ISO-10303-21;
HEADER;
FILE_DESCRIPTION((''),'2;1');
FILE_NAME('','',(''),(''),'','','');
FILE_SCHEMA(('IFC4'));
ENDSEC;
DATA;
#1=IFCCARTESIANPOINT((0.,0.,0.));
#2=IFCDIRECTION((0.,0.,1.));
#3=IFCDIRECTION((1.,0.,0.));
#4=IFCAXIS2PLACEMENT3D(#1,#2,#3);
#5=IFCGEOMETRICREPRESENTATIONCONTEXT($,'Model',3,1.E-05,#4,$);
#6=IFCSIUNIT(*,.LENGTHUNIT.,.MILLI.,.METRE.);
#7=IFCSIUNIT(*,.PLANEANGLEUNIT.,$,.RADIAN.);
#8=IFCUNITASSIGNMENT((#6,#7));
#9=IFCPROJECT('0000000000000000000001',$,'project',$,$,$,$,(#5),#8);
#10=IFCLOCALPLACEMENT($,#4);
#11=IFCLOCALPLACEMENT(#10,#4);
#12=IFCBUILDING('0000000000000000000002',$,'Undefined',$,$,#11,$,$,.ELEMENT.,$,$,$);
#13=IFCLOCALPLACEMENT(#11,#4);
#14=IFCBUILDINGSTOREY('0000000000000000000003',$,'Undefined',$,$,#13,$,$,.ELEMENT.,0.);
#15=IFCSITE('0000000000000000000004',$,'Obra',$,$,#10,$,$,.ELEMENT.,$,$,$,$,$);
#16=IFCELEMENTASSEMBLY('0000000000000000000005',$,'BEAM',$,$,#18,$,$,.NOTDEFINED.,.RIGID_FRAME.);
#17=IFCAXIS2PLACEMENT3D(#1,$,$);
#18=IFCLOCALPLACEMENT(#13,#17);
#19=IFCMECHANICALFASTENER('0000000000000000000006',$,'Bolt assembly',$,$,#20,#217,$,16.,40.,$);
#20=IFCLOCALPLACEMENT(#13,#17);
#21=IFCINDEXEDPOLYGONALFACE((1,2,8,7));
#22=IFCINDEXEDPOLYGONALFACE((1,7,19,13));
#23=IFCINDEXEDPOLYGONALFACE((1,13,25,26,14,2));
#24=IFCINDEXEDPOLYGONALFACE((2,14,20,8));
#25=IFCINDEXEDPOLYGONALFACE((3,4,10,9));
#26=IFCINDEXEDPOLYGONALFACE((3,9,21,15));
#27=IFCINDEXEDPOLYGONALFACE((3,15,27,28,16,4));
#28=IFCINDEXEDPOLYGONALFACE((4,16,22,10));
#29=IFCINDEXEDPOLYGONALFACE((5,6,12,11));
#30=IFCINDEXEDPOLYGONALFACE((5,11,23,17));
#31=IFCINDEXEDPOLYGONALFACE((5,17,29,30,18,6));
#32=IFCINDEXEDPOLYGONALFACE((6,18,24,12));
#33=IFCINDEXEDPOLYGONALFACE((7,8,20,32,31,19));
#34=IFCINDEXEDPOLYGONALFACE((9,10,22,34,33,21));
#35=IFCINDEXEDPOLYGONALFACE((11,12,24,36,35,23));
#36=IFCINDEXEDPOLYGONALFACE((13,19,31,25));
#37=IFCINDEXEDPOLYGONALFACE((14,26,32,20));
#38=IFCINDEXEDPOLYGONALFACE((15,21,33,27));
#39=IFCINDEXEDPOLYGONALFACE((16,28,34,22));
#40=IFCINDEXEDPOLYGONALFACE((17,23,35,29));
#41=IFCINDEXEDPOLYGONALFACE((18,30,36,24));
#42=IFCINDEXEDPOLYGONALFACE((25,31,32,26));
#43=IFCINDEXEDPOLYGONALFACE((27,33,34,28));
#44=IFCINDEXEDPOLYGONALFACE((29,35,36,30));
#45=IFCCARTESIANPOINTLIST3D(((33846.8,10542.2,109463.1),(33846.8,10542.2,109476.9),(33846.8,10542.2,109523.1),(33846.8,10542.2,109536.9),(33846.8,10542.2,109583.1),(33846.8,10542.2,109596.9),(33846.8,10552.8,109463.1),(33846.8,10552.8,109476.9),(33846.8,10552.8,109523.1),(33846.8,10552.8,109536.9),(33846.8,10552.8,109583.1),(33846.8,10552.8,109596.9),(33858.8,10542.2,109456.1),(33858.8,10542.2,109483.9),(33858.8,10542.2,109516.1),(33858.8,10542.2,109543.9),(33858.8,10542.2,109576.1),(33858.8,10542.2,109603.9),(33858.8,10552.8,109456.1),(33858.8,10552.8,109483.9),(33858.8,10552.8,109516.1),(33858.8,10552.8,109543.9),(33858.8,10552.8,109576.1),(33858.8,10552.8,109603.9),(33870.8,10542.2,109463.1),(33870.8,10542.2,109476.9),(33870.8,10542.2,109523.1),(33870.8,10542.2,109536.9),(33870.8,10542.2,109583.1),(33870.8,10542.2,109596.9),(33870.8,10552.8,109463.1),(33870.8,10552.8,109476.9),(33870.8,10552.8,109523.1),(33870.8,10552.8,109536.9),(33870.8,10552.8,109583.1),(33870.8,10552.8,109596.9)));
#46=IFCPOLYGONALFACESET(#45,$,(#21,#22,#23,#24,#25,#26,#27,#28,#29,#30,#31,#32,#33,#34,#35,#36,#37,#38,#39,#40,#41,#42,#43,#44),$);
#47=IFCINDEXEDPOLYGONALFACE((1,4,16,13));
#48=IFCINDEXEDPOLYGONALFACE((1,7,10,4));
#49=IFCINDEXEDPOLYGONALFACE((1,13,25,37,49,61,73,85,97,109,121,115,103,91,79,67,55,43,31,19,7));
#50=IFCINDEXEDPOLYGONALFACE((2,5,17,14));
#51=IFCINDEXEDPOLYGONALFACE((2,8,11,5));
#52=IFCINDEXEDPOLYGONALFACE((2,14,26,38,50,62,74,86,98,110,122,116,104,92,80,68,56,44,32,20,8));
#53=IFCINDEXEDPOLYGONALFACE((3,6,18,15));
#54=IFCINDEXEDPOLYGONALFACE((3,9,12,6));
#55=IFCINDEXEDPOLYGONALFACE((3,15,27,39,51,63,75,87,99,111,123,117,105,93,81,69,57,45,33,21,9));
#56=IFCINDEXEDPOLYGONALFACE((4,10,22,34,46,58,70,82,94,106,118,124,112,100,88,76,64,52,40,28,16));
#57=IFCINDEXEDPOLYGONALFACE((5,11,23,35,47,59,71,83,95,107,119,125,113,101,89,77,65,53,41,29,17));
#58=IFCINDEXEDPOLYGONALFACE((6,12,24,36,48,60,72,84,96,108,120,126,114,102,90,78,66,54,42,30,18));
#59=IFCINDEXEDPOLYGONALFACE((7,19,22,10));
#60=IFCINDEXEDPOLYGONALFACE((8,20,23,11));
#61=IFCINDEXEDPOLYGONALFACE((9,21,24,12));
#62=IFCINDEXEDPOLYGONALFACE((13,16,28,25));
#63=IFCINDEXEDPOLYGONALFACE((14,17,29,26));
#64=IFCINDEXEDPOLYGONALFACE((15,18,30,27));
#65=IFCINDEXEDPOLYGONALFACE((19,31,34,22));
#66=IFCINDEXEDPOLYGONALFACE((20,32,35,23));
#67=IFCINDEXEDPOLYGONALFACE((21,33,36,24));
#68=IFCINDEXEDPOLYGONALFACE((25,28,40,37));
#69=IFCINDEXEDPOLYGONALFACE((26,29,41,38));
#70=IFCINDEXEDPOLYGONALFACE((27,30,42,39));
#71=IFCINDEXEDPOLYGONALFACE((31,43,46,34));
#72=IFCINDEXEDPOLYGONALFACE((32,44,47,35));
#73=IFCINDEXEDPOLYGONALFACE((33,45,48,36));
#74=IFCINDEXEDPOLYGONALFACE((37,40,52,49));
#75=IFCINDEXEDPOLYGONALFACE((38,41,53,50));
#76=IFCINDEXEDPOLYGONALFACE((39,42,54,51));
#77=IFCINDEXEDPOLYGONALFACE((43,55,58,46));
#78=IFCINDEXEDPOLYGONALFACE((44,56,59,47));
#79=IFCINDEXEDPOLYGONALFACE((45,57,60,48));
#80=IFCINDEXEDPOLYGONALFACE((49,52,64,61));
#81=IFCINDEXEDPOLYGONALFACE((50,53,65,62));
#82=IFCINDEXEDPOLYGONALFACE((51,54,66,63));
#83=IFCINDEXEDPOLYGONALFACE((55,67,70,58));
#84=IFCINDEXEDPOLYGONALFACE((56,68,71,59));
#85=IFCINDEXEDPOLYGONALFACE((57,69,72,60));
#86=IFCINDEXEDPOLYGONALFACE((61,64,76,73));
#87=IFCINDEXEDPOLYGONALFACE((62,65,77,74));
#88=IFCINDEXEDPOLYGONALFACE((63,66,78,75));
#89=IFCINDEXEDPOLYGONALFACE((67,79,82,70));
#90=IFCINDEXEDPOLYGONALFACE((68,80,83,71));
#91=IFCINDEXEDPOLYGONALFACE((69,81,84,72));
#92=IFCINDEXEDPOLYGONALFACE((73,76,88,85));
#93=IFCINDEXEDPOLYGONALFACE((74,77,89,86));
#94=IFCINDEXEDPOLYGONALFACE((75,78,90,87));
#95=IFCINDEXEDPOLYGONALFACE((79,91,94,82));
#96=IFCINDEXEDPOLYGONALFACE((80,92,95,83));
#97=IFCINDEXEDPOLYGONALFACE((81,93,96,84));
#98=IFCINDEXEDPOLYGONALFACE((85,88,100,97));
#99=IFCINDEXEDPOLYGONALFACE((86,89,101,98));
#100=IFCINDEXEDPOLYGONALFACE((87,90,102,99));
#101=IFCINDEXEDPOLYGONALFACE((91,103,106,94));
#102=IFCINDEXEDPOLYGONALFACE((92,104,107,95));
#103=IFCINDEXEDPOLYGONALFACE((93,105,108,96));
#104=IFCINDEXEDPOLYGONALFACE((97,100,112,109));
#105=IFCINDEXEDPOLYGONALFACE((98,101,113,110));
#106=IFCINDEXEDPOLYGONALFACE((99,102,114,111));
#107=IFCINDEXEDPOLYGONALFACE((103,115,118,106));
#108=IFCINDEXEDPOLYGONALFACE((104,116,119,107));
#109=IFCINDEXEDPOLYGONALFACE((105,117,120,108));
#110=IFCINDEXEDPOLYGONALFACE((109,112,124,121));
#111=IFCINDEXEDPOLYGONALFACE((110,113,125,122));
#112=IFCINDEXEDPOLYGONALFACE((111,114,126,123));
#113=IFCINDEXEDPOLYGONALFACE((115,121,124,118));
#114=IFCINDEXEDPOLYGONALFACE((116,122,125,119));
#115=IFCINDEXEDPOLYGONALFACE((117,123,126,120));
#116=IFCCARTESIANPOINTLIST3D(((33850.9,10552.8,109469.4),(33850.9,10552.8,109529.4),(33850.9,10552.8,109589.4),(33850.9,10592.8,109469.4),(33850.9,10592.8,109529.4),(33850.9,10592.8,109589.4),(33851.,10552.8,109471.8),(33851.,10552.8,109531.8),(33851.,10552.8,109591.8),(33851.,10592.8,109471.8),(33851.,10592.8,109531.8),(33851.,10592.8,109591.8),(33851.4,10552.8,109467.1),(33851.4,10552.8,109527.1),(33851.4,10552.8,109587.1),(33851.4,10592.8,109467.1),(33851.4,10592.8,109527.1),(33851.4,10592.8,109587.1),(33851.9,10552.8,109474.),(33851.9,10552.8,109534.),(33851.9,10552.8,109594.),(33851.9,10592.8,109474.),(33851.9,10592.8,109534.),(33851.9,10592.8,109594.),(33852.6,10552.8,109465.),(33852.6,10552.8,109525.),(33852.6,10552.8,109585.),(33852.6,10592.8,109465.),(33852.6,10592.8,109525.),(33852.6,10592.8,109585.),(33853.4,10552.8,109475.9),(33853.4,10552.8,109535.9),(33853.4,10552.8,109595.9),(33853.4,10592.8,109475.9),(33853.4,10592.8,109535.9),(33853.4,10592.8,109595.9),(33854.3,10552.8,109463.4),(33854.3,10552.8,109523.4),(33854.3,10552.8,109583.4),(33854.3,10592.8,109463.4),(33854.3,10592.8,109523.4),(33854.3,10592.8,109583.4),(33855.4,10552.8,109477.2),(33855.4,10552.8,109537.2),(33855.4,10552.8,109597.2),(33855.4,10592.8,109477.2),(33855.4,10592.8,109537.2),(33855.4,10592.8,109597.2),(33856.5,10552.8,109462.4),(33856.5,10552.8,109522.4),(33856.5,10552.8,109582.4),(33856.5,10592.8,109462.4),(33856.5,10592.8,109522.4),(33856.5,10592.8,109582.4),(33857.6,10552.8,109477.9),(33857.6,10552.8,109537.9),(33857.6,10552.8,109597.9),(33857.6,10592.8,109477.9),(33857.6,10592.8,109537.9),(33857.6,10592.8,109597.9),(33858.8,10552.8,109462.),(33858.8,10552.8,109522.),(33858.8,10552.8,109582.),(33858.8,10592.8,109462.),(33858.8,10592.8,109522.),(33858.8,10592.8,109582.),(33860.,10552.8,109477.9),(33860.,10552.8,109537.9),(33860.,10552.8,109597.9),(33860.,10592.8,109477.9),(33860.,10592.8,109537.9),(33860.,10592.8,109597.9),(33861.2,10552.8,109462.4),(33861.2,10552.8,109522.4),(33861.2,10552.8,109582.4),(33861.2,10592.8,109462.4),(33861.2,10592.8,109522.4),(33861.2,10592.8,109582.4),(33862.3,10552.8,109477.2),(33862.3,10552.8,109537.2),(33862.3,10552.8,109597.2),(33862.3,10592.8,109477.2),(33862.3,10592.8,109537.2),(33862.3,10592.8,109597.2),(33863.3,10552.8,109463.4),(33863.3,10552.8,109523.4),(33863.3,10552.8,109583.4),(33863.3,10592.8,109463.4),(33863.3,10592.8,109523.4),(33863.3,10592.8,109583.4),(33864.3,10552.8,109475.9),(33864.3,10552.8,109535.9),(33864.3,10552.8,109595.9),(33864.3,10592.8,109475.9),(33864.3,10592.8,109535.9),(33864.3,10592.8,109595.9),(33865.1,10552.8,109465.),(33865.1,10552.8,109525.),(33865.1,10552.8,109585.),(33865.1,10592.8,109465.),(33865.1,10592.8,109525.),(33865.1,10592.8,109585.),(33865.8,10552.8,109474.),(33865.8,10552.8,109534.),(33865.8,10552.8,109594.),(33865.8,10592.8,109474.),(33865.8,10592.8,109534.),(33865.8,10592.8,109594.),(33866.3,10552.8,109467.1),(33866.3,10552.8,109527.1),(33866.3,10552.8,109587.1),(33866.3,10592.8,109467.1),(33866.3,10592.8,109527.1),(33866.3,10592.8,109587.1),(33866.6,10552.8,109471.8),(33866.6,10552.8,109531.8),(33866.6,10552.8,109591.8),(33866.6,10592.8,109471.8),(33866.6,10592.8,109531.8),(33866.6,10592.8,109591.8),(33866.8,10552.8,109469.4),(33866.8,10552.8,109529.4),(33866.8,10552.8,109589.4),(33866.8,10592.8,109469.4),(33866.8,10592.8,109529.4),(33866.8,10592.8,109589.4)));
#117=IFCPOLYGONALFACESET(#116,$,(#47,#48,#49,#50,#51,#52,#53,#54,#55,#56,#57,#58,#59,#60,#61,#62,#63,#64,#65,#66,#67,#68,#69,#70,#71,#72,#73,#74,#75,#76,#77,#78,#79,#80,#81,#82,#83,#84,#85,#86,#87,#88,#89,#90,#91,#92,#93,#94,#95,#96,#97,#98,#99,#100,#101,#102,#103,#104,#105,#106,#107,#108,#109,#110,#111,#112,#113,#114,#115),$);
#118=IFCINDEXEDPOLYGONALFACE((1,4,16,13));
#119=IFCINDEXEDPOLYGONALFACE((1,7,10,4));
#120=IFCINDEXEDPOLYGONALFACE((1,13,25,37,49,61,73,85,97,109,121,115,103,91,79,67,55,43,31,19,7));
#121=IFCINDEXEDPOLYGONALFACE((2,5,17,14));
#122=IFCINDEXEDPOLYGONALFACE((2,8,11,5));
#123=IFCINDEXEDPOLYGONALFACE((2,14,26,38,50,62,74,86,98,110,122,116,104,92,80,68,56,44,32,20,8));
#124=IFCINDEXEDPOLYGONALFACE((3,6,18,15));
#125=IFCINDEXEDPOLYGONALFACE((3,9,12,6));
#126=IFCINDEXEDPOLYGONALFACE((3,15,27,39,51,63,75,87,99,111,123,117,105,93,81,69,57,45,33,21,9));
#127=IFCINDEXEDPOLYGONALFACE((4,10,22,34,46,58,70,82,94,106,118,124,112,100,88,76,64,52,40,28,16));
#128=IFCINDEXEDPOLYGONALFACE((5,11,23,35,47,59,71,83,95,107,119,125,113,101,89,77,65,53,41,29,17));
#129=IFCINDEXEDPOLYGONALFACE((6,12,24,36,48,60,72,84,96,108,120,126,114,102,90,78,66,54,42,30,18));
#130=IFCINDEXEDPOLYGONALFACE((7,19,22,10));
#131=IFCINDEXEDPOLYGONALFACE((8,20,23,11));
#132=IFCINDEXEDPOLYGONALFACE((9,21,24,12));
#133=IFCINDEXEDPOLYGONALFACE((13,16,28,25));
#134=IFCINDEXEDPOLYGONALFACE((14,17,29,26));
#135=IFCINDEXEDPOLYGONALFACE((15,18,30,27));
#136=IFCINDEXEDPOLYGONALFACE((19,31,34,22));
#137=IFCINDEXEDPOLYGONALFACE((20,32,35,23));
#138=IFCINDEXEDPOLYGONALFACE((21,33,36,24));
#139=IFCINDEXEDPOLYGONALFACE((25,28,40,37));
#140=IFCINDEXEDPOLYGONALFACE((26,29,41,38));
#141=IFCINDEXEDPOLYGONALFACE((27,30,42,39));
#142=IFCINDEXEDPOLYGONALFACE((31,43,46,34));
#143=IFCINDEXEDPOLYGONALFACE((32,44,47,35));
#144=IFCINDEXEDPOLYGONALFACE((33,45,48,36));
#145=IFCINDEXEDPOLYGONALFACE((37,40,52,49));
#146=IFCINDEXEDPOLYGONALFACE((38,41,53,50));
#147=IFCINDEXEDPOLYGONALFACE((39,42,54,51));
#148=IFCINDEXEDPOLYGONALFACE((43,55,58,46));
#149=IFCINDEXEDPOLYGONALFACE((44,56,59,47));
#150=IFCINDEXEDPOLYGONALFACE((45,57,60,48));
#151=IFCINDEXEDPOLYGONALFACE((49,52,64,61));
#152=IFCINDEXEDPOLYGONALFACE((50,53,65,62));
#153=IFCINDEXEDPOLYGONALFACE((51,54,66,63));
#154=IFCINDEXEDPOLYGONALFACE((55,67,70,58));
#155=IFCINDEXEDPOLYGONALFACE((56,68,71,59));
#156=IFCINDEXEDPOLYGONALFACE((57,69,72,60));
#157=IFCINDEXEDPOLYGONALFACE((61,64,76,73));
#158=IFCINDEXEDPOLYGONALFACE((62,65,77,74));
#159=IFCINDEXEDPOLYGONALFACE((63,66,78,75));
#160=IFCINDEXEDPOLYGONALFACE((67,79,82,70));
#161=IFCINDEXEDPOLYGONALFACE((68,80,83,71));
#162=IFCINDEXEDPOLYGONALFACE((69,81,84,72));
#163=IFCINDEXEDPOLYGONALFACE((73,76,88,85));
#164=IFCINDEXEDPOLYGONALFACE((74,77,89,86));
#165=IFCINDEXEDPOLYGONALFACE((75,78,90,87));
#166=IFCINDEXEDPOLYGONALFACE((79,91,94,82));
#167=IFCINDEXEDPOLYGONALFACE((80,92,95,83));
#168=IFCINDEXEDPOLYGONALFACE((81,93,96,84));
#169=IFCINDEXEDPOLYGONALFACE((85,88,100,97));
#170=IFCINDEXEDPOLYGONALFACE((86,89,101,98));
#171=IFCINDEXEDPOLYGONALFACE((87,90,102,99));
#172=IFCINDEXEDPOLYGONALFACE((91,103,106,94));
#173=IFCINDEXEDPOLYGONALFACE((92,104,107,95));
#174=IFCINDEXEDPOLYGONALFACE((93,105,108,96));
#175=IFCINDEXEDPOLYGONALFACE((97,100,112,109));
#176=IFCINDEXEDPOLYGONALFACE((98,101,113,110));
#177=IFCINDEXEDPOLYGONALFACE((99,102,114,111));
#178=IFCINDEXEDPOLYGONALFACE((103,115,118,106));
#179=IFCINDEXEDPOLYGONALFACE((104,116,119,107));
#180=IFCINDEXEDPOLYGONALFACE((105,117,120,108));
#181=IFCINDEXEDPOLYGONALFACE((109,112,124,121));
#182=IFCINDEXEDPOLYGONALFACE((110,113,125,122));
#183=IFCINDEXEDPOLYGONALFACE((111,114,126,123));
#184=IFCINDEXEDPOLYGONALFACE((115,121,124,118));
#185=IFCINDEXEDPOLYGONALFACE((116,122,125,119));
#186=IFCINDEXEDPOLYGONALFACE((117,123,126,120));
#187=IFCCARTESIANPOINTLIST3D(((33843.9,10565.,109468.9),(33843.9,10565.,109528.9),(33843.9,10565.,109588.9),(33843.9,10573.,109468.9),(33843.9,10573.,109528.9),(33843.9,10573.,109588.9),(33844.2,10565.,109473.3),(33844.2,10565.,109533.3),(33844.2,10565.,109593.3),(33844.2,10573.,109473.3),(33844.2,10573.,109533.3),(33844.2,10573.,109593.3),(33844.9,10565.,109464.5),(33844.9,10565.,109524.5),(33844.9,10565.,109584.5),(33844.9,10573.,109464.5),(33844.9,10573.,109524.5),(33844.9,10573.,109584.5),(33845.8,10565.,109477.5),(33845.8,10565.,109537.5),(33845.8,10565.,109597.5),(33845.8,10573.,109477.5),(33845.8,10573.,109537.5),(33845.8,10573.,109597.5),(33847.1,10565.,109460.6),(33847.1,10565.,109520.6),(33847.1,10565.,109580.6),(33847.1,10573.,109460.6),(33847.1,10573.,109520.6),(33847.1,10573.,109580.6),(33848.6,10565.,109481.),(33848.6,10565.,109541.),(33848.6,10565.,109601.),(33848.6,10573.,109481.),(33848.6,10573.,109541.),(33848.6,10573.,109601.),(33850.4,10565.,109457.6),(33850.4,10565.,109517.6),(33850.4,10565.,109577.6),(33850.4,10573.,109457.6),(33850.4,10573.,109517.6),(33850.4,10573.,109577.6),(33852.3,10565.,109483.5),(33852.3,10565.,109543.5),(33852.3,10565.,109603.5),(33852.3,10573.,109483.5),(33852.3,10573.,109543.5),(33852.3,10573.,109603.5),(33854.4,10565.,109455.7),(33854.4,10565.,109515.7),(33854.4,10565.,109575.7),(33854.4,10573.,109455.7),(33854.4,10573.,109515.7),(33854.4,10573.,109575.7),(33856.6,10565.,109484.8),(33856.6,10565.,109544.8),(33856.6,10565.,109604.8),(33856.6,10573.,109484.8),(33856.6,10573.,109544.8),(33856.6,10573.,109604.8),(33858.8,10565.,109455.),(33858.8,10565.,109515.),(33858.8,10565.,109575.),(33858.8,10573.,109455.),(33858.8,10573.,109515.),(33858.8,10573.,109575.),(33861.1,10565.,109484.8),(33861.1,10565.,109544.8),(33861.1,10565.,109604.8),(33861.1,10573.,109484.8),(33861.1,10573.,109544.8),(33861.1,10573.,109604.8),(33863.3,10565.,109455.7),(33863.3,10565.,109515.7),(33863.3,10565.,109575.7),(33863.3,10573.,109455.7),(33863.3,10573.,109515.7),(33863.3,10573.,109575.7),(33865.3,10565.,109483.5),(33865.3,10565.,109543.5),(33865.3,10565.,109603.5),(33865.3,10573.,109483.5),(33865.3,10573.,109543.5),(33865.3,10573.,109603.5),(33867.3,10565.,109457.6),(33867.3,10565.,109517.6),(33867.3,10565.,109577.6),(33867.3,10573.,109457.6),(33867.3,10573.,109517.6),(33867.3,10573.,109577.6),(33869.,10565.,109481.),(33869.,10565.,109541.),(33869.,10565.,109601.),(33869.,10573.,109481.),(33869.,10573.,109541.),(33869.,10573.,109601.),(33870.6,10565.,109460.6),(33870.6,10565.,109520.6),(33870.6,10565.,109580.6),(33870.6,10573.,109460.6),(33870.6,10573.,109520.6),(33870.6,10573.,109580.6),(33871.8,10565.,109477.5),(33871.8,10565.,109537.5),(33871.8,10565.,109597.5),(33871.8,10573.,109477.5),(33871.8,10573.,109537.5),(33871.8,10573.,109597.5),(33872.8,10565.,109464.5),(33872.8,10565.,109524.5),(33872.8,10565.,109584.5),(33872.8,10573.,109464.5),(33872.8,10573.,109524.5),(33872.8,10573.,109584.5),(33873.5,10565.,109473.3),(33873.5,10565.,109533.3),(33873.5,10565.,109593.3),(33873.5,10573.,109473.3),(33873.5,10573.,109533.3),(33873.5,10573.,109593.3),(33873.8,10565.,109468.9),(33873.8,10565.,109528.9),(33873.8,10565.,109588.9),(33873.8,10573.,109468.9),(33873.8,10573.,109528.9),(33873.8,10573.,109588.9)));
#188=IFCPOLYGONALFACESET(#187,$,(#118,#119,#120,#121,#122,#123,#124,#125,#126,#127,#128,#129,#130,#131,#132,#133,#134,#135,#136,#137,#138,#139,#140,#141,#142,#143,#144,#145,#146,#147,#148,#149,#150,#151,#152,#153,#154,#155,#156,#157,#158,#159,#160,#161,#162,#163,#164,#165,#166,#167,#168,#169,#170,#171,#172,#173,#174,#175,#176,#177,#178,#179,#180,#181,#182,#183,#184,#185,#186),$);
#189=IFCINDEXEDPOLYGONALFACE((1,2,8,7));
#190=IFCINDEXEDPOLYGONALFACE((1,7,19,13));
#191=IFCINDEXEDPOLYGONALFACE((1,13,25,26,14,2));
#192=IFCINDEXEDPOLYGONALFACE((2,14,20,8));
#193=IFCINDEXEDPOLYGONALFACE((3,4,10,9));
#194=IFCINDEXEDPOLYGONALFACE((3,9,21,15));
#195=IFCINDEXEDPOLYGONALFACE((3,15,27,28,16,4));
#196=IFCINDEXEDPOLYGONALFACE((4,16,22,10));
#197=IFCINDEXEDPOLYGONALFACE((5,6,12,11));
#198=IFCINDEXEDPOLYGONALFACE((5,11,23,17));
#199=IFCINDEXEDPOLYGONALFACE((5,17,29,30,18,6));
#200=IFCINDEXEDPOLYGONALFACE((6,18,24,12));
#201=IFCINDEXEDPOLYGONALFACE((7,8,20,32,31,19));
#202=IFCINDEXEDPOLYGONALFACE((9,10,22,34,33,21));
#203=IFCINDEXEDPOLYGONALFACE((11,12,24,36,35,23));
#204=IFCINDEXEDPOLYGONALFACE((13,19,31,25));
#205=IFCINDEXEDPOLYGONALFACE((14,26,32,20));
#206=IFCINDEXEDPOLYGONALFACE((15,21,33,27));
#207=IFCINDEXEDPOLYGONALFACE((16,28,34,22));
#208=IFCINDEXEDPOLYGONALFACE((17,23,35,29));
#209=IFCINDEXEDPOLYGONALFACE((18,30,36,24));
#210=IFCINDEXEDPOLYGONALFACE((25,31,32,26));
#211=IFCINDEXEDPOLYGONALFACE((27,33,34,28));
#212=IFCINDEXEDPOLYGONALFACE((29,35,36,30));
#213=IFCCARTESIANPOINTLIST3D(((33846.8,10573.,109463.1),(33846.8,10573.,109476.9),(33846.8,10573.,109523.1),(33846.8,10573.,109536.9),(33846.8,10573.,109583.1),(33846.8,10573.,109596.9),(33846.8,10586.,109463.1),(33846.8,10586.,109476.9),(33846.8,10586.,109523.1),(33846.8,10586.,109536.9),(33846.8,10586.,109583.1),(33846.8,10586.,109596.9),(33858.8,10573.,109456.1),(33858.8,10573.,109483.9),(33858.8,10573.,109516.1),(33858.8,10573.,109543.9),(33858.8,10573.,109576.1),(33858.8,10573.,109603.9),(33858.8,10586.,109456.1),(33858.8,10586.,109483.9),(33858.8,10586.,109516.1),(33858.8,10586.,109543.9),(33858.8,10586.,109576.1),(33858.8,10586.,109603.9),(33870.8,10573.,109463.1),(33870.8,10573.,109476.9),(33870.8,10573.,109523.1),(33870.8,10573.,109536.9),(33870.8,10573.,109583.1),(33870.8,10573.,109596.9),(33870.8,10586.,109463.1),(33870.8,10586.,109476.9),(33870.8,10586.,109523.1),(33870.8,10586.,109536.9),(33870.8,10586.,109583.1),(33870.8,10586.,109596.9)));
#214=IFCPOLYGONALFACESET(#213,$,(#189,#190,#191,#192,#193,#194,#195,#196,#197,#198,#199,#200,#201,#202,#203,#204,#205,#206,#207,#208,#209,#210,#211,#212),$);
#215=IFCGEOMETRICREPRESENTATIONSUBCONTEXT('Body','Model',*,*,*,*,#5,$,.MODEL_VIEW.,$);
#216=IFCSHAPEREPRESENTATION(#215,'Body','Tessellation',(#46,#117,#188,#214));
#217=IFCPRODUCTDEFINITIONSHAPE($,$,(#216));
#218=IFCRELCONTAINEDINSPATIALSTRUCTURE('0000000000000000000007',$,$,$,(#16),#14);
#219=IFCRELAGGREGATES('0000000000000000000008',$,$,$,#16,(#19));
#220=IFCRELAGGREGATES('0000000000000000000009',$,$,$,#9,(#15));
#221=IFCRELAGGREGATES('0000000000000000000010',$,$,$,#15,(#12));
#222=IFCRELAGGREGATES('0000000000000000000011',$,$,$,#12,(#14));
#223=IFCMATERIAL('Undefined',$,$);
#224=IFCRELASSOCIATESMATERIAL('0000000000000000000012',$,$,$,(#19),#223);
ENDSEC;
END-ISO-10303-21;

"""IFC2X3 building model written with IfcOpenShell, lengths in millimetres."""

from ifc_helpers import new_model, si_unit, frame, origin_with_axes, origin_2d_with_axis, place, context, subcontext, project, spatial, polyline, circle, outline, extrude, source, transform, mapped, material, element, aggregate, save


model = new_model("IFC2X3")

# Units and contexts
model_context = context("Model", 3, precision=1e-05, world=origin_with_axes())
body_context = subcontext(model_context, "Body", "Model", "MODEL_VIEW")
ifc_project = project(units=[si_unit("LENGTHUNIT", "METRE", prefix="MILLI"), si_unit("PLANEANGLEUNIT", "RADIAN")], contexts=[model_context])

# Site, building, storey
site_placement = place(None, origin_with_axes())
site = spatial("IfcSite", under=ifc_project, at=site_placement, Name="Obra", CompositionType="ELEMENT")
building_placement = place(site_placement, origin_with_axes())
building = spatial("IfcBuilding", under=site, at=building_placement, Name="Undefined", CompositionType="ELEMENT")
storey_placement = place(building_placement, origin_with_axes())
storey = spatial("IfcBuildingStorey", under=building, at=storey_placement, Name="Undefined", CompositionType="ELEMENT", Elevation=0.0)

# Shared definitions
ifc_material_1 = material(Name="Undefined")

# Element assembly, mechanical fastener
assembly_1_placement = place(storey_placement, origin_with_axes())
assembly_1 = element("IfcElementAssembly", 1, at=assembly_1_placement, inside=storey, Name="BEAM", AssemblyPlace="NOTDEFINED", PredefinedType="RIGID_FRAME")
shared_shape_1 = source(origin_with_axes(), body_context, "Body", "SweptSolid", [
    extrude(outline(polyline([(13.9, 0.0), (6.9, 12.0), (-6.9, 12.0), (-13.9, 0.0), (-6.9, -12.0), (6.9, -12.0), (13.9, 0.0)])), frame((0.0, -19.7, 0.0), z_axis=(0.0, 1.0, 0.0), x_axis=(1.0, 0.0, 0.0)), (0.0, 0.0, 1.0), 10.6),
    extrude(circle(Radius=8.0, at=origin_2d_with_axis()), frame((0.0, -9.1, 0.0), z_axis=(0.0, 1.0, 0.0), x_axis=(1.0, 0.0, 0.0)), (0.0, 0.0, 1.0), 40.0),
    extrude(circle(Radius=15.0, at=origin_2d_with_axis()), frame((0.0, 3.1, 0.0), z_axis=(0.0, 1.0, 0.0), x_axis=(1.0, 0.0, 0.0)), (0.0, 0.0, 1.0), 8.0),
    extrude(outline(polyline([(13.9, 0.0), (6.9, 12.0), (-6.9, 12.0), (-13.9, 0.0), (-6.9, -12.0), (6.9, -12.0), (13.9, 0.0)])), frame((0.0, 11.1, 0.0), z_axis=(0.0, 1.0, 0.0), x_axis=(1.0, 0.0, 0.0)), (0.0, 0.0, 1.0), 13.0),
])
mechanical_fastener_1_placement = place(assembly_1_placement, frame((33808.8, 10561.9, 109650.0), z_axis=(1.0, -0.000126, 0.0), x_axis=(0.0, 0.0, -1.0)))
mechanical_fastener_1 = element("IfcMechanicalFastener", 2, at=mechanical_fastener_1_placement, material=ifc_material_1, Name="Bolt assembly", NominalDiameter=16.0, NominalLength=40.0, context=body_context, shape_type="MappedRepresentation", body=[
    mapped(shared_shape_1, transform((60.0, 0.0, 50.0))),
    mapped(shared_shape_1, transform((120.0, 0.0, 50.0))),
    mapped(shared_shape_1, transform((180.0, 0.0, 50.0))),
])
aggregate(assembly_1, [mechanical_fastener_1])

save(model, "model.ifc")
